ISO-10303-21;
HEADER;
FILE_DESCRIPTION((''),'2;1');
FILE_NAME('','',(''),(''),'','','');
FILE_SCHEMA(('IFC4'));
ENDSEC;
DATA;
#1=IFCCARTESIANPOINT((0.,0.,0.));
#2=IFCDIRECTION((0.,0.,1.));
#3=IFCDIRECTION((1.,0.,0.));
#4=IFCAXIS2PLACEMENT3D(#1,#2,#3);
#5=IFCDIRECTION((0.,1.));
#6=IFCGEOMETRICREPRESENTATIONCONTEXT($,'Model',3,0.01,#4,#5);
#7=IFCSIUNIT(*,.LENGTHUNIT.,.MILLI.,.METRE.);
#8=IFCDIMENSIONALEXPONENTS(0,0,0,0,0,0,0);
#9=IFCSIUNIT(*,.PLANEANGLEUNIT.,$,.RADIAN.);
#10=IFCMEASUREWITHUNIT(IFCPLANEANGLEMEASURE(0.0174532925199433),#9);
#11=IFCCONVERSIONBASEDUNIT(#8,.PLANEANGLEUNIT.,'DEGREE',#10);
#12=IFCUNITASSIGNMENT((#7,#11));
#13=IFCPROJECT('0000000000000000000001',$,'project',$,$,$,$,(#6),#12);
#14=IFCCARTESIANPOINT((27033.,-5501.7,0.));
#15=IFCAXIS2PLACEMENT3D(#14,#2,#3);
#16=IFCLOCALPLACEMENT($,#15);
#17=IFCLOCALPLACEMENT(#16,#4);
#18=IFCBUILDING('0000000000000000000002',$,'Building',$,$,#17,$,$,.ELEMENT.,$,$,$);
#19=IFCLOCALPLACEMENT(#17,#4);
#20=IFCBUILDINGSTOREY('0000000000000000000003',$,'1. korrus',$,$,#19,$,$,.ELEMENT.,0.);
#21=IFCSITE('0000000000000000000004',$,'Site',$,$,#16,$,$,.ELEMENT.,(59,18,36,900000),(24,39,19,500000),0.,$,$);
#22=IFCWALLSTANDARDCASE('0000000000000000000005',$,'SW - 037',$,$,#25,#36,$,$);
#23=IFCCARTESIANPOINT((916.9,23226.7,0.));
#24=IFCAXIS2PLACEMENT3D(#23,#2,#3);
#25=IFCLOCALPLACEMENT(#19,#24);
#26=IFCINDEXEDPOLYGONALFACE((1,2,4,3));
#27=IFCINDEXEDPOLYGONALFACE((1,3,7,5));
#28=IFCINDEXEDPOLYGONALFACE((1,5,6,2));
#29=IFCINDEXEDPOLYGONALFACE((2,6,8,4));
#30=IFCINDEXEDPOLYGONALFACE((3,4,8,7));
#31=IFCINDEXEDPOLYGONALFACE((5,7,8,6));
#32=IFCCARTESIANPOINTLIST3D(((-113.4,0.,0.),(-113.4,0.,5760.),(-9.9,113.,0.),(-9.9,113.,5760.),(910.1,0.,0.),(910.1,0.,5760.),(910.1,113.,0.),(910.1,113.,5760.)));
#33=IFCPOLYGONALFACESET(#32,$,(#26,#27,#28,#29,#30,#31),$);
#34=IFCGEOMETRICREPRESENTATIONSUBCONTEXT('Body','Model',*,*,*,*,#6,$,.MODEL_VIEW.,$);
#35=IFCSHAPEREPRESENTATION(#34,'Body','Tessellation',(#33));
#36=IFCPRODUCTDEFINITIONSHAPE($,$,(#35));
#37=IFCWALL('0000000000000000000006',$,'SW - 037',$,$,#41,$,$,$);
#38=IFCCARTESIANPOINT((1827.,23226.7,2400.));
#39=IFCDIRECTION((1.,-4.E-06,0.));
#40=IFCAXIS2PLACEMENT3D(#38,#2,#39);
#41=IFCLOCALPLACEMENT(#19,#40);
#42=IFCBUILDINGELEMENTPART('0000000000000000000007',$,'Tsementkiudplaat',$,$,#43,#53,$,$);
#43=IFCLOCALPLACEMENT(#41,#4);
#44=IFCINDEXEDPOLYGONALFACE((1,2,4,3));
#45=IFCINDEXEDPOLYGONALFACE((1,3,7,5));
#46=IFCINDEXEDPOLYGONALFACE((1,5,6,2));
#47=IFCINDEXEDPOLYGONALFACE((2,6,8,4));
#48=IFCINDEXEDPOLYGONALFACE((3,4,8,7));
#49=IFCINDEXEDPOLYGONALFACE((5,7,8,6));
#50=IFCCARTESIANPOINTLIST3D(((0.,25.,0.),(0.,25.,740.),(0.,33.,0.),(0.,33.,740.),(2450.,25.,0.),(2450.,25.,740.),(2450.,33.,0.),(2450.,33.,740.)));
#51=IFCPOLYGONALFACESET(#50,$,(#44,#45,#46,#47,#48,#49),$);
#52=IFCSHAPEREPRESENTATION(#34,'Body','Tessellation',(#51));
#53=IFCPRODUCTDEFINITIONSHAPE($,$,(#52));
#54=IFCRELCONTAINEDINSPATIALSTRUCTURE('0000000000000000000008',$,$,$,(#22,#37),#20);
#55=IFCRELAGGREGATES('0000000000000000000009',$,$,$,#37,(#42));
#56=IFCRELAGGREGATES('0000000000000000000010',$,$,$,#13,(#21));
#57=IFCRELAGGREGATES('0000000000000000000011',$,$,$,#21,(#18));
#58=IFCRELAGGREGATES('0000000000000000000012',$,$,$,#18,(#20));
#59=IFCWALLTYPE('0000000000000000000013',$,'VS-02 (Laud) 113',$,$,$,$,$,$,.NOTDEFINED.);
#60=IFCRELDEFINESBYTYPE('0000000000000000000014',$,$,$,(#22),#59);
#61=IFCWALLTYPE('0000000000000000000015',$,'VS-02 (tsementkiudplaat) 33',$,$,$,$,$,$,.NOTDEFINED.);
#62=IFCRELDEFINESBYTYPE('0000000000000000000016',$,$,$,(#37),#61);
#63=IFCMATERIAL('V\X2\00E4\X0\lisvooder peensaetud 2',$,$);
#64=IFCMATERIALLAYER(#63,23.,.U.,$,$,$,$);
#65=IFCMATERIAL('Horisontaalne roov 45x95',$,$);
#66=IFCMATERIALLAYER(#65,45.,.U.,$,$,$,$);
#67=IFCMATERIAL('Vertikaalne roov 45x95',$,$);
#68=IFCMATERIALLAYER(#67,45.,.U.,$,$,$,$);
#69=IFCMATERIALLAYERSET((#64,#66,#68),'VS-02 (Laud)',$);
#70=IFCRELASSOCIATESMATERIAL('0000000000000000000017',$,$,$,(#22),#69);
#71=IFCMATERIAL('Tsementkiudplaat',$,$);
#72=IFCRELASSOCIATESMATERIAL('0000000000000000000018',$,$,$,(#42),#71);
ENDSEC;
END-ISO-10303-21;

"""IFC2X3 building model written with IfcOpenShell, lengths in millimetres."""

from ifc_helpers import new_model, entity, si_unit, converted_unit, direction, frame, origin_with_axes, place, context, subcontext, project, spatial, polyline, outline, extrude, material, layer, layer_set, layer_usage, type_object, element, aggregate, save


model = new_model("IFC2X3")

# Units and contexts
model_context = context("Model", 3, precision=0.01, world=origin_with_axes(), true_north=direction((0.0, 1.0)))
body_context = subcontext(model_context, "Body", "Model", "MODEL_VIEW")
ifc_project = project(units=[si_unit("LENGTHUNIT", "METRE", prefix="MILLI"), converted_unit("PLANEANGLEUNIT", "DEGREE", entity("IfcPlaneAngleMeasure", 0.0174532925199433), si_unit("PLANEANGLEUNIT", "RADIAN"), dimensions=[0, 0, 0, 0, 0, 0, 0])], contexts=[model_context])

# Site, building, storey
site_placement = place(None, frame((27033.0, -5501.7, 0.0), z_axis=(0.0, 0.0, 1.0), x_axis=(1.0, 0.0, 0.0)))
site = spatial("IfcSite", under=ifc_project, at=site_placement, Name="Site", CompositionType="ELEMENT", RefLatitude=(59, 18, 36, 900000), RefLongitude=(24, 39, 19, 500000), RefElevation=0.0)
building_placement = place(site_placement, origin_with_axes())
building = spatial("IfcBuilding", under=site, at=building_placement, Name="Building", CompositionType="ELEMENT")
storey_placement = place(building_placement, origin_with_axes())
storey = spatial("IfcBuildingStorey", under=building, at=storey_placement, Name="1. korrus", CompositionType="ELEMENT", Elevation=0.0)

# Wall
ifc_material_1 = material(Name="Välisvooder peensaetud 2")
ifc_layer_1 = layer(ifc_material_1, 23.0, ventilated="UNKNOWN")
ifc_material_2 = material(Name="Horisontaalne roov 45x95")
ifc_layer_2 = layer(ifc_material_2, 45.0, ventilated="UNKNOWN")
ifc_material_3 = material(Name="Vertikaalne roov 45x95")
ifc_layer_3 = layer(ifc_material_3, 45.0, ventilated="UNKNOWN")
ifc_layer_set_1 = layer_set([ifc_layer_1, ifc_layer_2, ifc_layer_3], Name="VS-02 (Laud)")
ifc_layer_usage_1 = layer_usage(ifc_layer_set_1, "AXIS2", "NEGATIVE", 113.0)
wall_type_1 = type_object("IfcWallType", Name="VS-02 (Laud) 113", PredefinedType="NOTDEFINED")
wall_1_placement = place(storey_placement, frame((916.9, 23226.7, 0.0), z_axis=(0.0, 0.0, 1.0), x_axis=(1.0, 0.0, 0.0)))
element("IfcWallStandardCase", 1, at=wall_1_placement, inside=storey, type_object=wall_type_1, material=ifc_layer_usage_1, Name="SW - 037", context=body_context, shape_type="SweptSolid", body=[
    extrude(outline(polyline([(-113.4, 0.0), (910.1, 0.0), (910.1, 113.0), (-9.9, 113.0), (-113.4, 0.0)])), origin_with_axes(), (0.0, 0.0, 1.0), 5760.0),
])
ifc_material_4 = material(Name="Tsementkiudplaat")
wall_type_2 = type_object("IfcWallType", Name="VS-02 (tsementkiudplaat) 33", PredefinedType="NOTDEFINED")

# Wall, building element part
wall_2_placement = place(storey_placement, frame((1827.0, 23226.7, 2400.0), z_axis=(0.0, 0.0, 1.0), x_axis=(1.0, -0.000004, 0.0)))
wall_2 = element("IfcWall", 2, at=wall_2_placement, inside=storey, type_object=wall_type_2, Name="SW - 037")
building_element_part_1_placement = place(wall_2_placement, origin_with_axes())
building_element_part_1 = element("IfcBuildingElementPart", 3, at=building_element_part_1_placement, material=ifc_material_4, Name="Tsementkiudplaat", context=body_context, shape_type="SweptSolid", body=[
    extrude(outline(polyline([(25.0, 0.0), (33.0, 0.0), (33.0, 740.0), (25.0, 740.0), (25.0, 0.0)])), frame((0.0, 0.0, 0.0), z_axis=(1.0, 0.0, 0.0), x_axis=(0.0, 1.0, 0.0)), (0.0, 0.0, 1.0), 2450.0),
])
aggregate(wall_2, [building_element_part_1])

save(model, "model.ifc")
